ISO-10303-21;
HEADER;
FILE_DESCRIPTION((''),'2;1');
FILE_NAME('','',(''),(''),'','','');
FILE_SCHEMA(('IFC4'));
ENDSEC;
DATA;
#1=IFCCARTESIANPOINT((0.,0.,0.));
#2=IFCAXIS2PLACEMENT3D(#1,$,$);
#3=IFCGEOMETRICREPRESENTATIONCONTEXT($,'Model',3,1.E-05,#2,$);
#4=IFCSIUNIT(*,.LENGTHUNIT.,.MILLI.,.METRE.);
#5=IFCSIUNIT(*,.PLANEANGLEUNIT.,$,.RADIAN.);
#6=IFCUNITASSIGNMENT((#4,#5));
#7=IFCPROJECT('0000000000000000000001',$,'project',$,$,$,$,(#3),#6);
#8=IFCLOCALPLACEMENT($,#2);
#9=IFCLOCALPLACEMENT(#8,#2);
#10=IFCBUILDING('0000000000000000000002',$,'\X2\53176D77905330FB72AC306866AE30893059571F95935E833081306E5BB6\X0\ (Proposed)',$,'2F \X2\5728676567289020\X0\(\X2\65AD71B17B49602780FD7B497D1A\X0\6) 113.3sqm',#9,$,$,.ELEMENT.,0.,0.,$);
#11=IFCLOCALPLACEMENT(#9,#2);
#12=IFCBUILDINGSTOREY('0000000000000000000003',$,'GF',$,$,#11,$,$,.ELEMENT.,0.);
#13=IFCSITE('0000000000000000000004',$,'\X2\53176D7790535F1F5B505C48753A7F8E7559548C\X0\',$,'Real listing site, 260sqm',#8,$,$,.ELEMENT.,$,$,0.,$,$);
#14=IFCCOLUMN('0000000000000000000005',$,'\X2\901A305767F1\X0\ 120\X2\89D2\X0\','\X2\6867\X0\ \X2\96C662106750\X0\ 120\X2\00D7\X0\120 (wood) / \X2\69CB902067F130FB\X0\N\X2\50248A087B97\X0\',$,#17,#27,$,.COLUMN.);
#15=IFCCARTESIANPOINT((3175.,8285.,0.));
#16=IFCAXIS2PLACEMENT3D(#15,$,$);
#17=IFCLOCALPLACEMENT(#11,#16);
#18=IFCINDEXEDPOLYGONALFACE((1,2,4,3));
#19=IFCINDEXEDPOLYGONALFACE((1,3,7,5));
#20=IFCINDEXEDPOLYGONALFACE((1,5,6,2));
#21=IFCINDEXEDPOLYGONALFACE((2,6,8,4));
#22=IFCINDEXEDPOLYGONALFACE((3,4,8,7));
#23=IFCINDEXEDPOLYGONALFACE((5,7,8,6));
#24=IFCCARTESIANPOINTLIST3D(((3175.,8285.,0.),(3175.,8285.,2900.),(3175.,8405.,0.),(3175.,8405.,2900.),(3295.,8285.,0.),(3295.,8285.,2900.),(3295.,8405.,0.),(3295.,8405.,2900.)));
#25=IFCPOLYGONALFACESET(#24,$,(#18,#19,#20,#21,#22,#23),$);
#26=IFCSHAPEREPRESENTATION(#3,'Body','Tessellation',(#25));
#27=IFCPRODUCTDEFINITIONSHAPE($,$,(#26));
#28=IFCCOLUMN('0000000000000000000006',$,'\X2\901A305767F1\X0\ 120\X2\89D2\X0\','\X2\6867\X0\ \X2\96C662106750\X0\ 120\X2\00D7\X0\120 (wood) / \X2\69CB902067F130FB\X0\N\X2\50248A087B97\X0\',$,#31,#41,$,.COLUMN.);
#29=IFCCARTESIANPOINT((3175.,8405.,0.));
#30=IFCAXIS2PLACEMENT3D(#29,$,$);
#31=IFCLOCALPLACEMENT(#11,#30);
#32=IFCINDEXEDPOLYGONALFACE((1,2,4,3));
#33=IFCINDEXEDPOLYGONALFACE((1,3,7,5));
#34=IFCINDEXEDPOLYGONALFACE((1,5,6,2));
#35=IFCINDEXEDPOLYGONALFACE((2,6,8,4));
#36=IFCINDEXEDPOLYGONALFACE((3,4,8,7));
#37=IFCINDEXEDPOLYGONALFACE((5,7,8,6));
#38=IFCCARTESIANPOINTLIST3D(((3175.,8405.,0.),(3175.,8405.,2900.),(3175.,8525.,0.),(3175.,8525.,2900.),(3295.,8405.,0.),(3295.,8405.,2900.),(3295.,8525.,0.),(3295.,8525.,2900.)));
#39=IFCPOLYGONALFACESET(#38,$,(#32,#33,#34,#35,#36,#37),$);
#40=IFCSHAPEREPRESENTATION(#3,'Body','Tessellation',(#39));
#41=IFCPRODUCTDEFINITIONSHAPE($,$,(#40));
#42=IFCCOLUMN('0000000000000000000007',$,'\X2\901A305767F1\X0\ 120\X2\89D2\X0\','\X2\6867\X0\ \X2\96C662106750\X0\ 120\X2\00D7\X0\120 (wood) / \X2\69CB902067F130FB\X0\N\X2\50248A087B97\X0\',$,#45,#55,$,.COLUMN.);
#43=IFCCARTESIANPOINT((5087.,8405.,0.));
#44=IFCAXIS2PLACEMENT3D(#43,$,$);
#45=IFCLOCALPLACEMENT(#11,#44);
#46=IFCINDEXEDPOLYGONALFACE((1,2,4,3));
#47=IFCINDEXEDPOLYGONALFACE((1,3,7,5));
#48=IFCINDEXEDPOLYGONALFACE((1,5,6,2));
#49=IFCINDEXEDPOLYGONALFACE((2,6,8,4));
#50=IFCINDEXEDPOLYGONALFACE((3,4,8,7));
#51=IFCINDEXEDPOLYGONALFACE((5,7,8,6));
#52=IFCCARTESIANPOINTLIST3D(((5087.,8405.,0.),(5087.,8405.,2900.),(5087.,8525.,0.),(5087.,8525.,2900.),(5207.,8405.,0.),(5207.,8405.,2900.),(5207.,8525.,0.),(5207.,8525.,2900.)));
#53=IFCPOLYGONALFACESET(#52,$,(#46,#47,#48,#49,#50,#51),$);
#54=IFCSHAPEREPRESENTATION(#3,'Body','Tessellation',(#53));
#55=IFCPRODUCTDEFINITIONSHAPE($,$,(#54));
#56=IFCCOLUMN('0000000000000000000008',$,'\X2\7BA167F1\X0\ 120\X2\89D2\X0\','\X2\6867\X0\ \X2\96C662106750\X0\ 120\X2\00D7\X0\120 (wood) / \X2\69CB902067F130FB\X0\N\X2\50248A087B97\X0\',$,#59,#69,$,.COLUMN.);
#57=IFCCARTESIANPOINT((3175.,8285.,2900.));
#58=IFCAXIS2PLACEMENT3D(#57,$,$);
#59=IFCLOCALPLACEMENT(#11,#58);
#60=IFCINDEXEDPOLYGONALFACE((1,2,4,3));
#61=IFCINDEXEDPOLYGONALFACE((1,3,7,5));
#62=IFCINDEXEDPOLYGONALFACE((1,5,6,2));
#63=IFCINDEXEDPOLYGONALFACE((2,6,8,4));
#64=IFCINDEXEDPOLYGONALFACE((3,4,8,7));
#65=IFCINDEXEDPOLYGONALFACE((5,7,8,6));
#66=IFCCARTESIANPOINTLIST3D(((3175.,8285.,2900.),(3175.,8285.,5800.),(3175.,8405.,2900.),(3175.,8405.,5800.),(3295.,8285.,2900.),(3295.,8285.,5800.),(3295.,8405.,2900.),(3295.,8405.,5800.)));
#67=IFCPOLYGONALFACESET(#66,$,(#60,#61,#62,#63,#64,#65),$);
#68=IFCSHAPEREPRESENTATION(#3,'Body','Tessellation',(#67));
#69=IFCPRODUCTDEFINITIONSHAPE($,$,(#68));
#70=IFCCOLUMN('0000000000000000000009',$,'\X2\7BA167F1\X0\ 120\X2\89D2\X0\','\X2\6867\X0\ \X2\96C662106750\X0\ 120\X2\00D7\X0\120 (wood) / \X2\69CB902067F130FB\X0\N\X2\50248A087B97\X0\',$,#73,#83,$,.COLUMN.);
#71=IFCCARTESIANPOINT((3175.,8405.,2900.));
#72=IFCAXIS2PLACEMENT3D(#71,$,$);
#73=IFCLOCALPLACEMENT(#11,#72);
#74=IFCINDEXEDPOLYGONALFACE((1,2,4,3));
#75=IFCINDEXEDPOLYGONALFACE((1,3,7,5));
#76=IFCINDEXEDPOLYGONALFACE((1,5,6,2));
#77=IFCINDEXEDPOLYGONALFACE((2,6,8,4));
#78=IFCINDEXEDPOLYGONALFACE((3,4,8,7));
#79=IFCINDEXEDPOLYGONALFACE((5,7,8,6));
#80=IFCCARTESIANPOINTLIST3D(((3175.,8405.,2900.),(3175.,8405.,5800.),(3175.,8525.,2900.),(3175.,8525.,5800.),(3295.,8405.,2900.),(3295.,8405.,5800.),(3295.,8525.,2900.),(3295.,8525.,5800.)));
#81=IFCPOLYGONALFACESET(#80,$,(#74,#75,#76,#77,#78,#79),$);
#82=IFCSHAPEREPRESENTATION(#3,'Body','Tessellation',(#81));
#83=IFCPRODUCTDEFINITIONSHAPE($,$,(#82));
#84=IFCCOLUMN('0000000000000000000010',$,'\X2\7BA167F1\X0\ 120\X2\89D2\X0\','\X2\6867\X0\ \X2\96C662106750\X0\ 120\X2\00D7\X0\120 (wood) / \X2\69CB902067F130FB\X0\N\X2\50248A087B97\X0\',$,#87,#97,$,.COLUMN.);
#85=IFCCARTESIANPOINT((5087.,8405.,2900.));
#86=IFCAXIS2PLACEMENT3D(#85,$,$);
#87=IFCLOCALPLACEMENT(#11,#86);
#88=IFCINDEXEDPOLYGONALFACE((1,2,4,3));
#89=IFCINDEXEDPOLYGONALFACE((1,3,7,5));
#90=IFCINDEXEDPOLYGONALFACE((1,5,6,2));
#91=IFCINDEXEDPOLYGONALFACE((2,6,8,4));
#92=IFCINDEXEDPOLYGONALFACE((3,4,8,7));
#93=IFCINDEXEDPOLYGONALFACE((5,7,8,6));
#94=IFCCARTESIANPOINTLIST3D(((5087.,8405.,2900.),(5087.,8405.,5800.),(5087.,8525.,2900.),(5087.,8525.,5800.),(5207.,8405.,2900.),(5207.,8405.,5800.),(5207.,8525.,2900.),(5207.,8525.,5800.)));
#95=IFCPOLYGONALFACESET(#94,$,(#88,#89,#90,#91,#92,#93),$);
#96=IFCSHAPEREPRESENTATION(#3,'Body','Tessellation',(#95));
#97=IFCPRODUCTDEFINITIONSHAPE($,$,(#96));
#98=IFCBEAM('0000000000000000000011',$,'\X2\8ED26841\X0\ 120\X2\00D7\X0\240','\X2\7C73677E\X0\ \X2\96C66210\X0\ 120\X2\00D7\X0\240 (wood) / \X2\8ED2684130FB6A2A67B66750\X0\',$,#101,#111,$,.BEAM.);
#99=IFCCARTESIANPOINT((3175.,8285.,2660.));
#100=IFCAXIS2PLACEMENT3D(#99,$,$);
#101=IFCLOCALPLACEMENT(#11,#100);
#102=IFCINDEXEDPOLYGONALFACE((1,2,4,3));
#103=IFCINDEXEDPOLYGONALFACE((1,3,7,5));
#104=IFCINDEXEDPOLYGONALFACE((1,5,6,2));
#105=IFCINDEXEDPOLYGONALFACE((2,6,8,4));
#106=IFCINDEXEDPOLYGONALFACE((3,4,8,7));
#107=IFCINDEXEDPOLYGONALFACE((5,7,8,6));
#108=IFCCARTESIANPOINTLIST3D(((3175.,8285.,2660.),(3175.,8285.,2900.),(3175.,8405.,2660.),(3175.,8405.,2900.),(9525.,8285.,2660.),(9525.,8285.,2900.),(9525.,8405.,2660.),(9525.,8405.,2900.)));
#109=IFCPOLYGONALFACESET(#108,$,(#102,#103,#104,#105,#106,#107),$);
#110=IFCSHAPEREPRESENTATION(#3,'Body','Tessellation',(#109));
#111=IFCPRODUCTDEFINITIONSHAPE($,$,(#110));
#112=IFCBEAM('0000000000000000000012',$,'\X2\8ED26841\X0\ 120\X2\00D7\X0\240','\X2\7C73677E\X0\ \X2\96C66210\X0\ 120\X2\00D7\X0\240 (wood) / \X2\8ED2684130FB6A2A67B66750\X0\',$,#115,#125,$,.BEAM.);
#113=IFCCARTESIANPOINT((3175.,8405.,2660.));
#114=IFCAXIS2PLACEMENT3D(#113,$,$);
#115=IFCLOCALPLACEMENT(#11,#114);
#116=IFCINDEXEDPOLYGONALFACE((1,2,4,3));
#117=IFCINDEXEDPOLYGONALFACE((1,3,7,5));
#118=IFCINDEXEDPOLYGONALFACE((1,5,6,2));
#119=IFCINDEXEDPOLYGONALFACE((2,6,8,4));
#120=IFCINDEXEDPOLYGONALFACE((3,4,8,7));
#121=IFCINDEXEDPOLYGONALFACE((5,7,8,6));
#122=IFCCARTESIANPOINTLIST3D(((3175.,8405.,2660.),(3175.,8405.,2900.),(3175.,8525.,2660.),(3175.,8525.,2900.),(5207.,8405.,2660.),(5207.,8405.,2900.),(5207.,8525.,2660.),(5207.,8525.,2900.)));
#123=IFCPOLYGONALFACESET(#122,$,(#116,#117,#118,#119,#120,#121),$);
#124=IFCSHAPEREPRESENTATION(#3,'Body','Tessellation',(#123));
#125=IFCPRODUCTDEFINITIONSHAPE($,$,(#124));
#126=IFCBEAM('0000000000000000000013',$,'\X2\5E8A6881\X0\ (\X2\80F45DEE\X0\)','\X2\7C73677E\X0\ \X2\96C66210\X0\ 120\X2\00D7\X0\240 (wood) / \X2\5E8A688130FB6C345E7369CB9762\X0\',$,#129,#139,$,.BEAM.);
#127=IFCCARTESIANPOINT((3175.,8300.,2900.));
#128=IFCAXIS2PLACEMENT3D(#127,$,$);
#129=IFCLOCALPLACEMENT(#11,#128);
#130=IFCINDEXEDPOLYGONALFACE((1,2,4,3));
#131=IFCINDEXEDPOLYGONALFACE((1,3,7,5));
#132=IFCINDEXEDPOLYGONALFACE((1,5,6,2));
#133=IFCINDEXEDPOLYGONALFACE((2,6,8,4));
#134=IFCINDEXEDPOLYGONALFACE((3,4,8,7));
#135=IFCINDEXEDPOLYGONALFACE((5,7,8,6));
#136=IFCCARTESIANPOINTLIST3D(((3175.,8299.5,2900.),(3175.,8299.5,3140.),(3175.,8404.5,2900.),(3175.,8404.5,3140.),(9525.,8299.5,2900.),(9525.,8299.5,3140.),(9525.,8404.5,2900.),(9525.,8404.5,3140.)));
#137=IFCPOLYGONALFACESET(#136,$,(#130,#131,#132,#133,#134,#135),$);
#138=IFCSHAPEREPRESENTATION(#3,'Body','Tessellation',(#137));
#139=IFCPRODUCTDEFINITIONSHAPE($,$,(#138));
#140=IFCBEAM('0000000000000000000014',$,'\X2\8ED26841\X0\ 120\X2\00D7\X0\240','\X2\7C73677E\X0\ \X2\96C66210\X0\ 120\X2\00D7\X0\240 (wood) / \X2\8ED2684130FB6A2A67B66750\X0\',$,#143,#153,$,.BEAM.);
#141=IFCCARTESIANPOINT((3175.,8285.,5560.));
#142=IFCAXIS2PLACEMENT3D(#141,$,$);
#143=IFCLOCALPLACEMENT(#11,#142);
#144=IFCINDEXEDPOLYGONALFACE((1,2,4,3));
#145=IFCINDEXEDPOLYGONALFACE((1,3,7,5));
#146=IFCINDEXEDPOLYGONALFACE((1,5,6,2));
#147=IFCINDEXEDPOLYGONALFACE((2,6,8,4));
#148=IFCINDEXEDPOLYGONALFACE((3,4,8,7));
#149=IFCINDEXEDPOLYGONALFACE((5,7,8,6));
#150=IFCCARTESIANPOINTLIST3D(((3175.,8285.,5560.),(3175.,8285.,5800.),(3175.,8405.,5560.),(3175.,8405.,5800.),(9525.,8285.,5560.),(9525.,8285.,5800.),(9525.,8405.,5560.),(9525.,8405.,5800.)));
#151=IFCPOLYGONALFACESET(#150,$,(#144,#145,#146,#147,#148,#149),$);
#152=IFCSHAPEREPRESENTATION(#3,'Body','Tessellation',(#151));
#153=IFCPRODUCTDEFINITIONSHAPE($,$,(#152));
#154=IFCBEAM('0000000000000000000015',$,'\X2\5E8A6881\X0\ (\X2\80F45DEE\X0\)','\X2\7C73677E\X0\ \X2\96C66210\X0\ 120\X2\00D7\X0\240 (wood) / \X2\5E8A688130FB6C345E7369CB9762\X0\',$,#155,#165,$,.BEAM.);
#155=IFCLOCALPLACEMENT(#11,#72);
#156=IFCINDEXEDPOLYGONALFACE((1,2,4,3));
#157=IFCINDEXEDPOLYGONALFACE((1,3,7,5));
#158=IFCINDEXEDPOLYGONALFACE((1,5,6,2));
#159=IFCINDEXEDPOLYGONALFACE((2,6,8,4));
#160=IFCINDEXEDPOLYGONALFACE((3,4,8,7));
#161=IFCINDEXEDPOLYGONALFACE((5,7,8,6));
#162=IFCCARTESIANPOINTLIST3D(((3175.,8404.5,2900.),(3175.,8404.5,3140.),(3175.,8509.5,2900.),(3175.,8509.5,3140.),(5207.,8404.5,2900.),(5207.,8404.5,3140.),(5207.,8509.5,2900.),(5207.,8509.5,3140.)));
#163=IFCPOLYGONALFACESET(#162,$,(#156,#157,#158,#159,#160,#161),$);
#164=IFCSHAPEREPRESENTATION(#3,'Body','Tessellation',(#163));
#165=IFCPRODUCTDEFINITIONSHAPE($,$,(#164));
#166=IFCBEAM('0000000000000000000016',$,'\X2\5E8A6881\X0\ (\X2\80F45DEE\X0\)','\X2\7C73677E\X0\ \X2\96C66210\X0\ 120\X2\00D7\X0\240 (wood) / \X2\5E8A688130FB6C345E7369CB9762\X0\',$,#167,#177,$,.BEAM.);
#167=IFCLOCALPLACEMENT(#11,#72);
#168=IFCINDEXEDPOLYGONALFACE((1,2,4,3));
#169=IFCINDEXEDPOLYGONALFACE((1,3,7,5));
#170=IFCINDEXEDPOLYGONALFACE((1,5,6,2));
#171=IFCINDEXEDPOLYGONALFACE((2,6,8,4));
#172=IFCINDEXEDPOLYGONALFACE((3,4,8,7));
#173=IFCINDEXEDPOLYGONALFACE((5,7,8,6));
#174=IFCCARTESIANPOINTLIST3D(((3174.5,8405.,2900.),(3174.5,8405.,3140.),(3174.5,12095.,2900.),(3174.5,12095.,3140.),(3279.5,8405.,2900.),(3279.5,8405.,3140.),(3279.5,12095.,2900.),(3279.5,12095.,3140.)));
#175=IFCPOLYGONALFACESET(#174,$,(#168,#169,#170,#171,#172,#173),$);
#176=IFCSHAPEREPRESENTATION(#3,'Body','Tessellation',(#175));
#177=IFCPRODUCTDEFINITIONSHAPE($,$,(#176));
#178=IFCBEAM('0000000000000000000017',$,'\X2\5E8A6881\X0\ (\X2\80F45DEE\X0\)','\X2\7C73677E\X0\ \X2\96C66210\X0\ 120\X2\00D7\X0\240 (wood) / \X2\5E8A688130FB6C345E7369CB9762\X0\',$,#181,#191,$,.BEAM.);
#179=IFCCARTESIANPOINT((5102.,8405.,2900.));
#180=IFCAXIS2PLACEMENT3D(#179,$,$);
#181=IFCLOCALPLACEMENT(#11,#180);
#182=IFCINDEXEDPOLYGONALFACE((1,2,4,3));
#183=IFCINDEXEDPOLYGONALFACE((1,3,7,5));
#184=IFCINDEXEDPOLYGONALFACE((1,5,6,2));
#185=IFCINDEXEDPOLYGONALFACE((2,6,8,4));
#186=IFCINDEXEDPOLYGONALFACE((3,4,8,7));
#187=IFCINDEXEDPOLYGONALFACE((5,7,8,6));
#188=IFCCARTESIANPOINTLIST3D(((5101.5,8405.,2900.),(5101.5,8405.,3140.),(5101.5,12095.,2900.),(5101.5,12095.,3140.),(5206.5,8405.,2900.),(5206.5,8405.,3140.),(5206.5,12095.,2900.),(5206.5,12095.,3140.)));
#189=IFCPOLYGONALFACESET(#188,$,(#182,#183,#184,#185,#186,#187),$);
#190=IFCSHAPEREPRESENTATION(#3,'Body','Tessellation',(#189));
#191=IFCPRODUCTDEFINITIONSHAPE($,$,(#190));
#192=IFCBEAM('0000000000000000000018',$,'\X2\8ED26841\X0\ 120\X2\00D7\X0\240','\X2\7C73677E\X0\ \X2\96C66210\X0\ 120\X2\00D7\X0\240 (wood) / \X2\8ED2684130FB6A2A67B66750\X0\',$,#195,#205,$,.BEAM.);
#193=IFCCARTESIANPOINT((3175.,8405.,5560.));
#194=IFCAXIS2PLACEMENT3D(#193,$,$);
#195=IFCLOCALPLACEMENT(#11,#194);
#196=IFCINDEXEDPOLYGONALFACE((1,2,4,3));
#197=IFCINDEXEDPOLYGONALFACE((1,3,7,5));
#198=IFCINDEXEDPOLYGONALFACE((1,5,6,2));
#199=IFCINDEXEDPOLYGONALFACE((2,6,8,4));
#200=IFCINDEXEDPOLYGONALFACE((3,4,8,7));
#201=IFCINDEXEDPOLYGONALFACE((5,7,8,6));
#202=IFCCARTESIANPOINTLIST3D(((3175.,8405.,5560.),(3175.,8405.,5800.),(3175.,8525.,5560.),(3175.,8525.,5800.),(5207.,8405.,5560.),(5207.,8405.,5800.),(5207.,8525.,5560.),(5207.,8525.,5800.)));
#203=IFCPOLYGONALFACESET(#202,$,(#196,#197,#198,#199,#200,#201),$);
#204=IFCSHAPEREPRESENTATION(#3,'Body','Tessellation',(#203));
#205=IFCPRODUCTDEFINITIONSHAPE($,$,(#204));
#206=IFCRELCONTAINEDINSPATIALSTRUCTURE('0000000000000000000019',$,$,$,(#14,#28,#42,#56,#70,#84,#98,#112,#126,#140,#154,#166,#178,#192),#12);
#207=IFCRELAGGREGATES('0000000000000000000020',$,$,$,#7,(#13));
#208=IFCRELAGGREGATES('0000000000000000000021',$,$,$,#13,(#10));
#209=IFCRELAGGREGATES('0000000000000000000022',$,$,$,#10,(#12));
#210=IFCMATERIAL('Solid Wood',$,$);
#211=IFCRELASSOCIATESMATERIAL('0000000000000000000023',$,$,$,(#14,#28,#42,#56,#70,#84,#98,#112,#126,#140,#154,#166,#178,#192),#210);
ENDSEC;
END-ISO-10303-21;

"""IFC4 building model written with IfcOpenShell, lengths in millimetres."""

from ifc_helpers import new_model, si_unit, frame, frame_2d, origin, place, context, project, spatial, rectangle, extrude, material, element, save


model = new_model("IFC4")

# Units and contexts
model_context = context("Model", 3, precision=1e-05, world=origin())
ifc_project = project(units=[si_unit("LENGTHUNIT", "METRE", prefix="MILLI"), si_unit("PLANEANGLEUNIT", "RADIAN")], contexts=[model_context])

# Site, building, storey
site_placement = place(None, origin())
site = spatial("IfcSite", under=ifc_project, at=site_placement, Name="北海道弟子屈町美留和", ObjectType="Real listing site, 260sqm", CompositionType="ELEMENT", RefElevation=0.0)
building_placement = place(site_placement, origin())
building = spatial("IfcBuilding", under=site, at=building_placement, Name="北海道・犬と暮らす土間広めの家 (Proposed)", ObjectType="2F 在来木造(断熱等性能等級6) 113.3sqm", CompositionType="ELEMENT", ElevationOfRefHeight=0.0, ElevationOfTerrain=0.0)
storey_placement = place(building_placement, origin())
storey = spatial("IfcBuildingStorey", under=building, at=storey_placement, Name="GF", CompositionType="ELEMENT", Elevation=0.0)

# Columns
ifc_material_1 = material(Name="Solid Wood")
column_1_placement = place(storey_placement, frame((3175.0, 8285.0, 0.0)))
element("IfcColumn", 1, at=column_1_placement, inside=storey, material=ifc_material_1, Name="通し柱 120角", Description="桧 集成材 120×120 (wood) / 構造柱・N値計算", PredefinedType="COLUMN", context=model_context, shape_type="SweptSolid", body=[
    extrude(rectangle(XDim=120.0, YDim=120.0, at=frame_2d((60.0, 60.0))), frame((3175.0, 8285.0, 0.0)), (0.0, 0.0, 1.0), 2900.0),
])
column_2_placement = place(storey_placement, frame((3175.0, 8405.0, 0.0)))
element("IfcColumn", 2, at=column_2_placement, inside=storey, material=ifc_material_1, Name="通し柱 120角", Description="桧 集成材 120×120 (wood) / 構造柱・N値計算", PredefinedType="COLUMN", context=model_context, shape_type="SweptSolid", body=[
    extrude(rectangle(XDim=120.0, YDim=120.0, at=frame_2d((60.0, 60.0))), frame((3175.0, 8405.0, 0.0)), (0.0, 0.0, 1.0), 2900.0),
])
column_3_placement = place(storey_placement, frame((5087.0, 8405.0, 0.0)))
element("IfcColumn", 3, at=column_3_placement, inside=storey, material=ifc_material_1, Name="通し柱 120角", Description="桧 集成材 120×120 (wood) / 構造柱・N値計算", PredefinedType="COLUMN", context=model_context, shape_type="SweptSolid", body=[
    extrude(rectangle(XDim=120.0, YDim=120.0, at=frame_2d((60.0, 60.0))), frame((5087.0, 8405.0, 0.0)), (0.0, 0.0, 1.0), 2900.0),
])
column_4_placement = place(storey_placement, frame((3175.0, 8285.0, 2900.0)))
element("IfcColumn", 4, at=column_4_placement, inside=storey, material=ifc_material_1, Name="管柱 120角", Description="桧 集成材 120×120 (wood) / 構造柱・N値計算", PredefinedType="COLUMN", context=model_context, shape_type="SweptSolid", body=[
    extrude(rectangle(XDim=120.0, YDim=120.0, at=frame_2d((60.0, 60.0))), frame((3175.0, 8285.0, 2900.0)), (0.0, 0.0, 1.0), 2900.0),
])
column_5_placement = place(storey_placement, frame((3175.0, 8405.0, 2900.0)))
element("IfcColumn", 5, at=column_5_placement, inside=storey, material=ifc_material_1, Name="管柱 120角", Description="桧 集成材 120×120 (wood) / 構造柱・N値計算", PredefinedType="COLUMN", context=model_context, shape_type="SweptSolid", body=[
    extrude(rectangle(XDim=120.0, YDim=120.0, at=frame_2d((60.0, 60.0))), frame((3175.0, 8405.0, 2900.0)), (0.0, 0.0, 1.0), 2900.0),
])
column_6_placement = place(storey_placement, frame((5087.0, 8405.0, 2900.0)))
element("IfcColumn", 6, at=column_6_placement, inside=storey, material=ifc_material_1, Name="管柱 120角", Description="桧 集成材 120×120 (wood) / 構造柱・N値計算", PredefinedType="COLUMN", context=model_context, shape_type="SweptSolid", body=[
    extrude(rectangle(XDim=120.0, YDim=120.0, at=frame_2d((60.0, 60.0))), frame((5087.0, 8405.0, 2900.0)), (0.0, 0.0, 1.0), 2900.0),
])

# Beams
beam_1_placement = place(storey_placement, frame((3175.0, 8285.0, 2660.0)))
element("IfcBeam", 7, at=beam_1_placement, inside=storey, material=ifc_material_1, Name="軒桁 120×240", Description="米松 集成 120×240 (wood) / 軒桁・横架材", PredefinedType="BEAM", context=model_context, shape_type="SweptSolid", body=[
    extrude(rectangle(XDim=6350.0, YDim=120.0, at=frame_2d((3175.0, 60.0))), frame((3175.0, 8285.0, 2660.0)), (0.0, 0.0, 1.0), 240.0),
])
beam_2_placement = place(storey_placement, frame((3175.0, 8405.0, 2660.0)))
element("IfcBeam", 8, at=beam_2_placement, inside=storey, material=ifc_material_1, Name="軒桁 120×240", Description="米松 集成 120×240 (wood) / 軒桁・横架材", PredefinedType="BEAM", context=model_context, shape_type="SweptSolid", body=[
    extrude(rectangle(XDim=2032.0, YDim=120.0, at=frame_2d((1016.0, 60.0))), frame((3175.0, 8405.0, 2660.0)), (0.0, 0.0, 1.0), 240.0),
])
beam_3_placement = place(storey_placement, frame((3175.0, 8300.0, 2900.0)))
element("IfcBeam", 9, at=beam_3_placement, inside=storey, material=ifc_material_1, Name="床梁 (胴差)", Description="米松 集成 120×240 (wood) / 床梁・水平構面", PredefinedType="BEAM", context=model_context, shape_type="SweptSolid", body=[
    extrude(rectangle(XDim=6350.0, YDim=105.0, at=frame_2d((3175.0, 52.0))), frame((3175.0, 8300.0, 2900.0)), (0.0, 0.0, 1.0), 240.0),
])
beam_4_placement = place(storey_placement, frame((3175.0, 8285.0, 5560.0)))
element("IfcBeam", 10, at=beam_4_placement, inside=storey, material=ifc_material_1, Name="軒桁 120×240", Description="米松 集成 120×240 (wood) / 軒桁・横架材", PredefinedType="BEAM", context=model_context, shape_type="SweptSolid", body=[
    extrude(rectangle(XDim=6350.0, YDim=120.0, at=frame_2d((3175.0, 60.0))), frame((3175.0, 8285.0, 5560.0)), (0.0, 0.0, 1.0), 240.0),
])
beam_5_placement = place(storey_placement, frame((3175.0, 8405.0, 2900.0)))
element("IfcBeam", 11, at=beam_5_placement, inside=storey, material=ifc_material_1, Name="床梁 (胴差)", Description="米松 集成 120×240 (wood) / 床梁・水平構面", PredefinedType="BEAM", context=model_context, shape_type="SweptSolid", body=[
    extrude(rectangle(XDim=2032.0, YDim=105.0, at=frame_2d((1016.0, 52.0))), frame((3175.0, 8405.0, 2900.0)), (0.0, 0.0, 1.0), 240.0),
])
beam_6_placement = place(storey_placement, frame((3175.0, 8405.0, 2900.0)))
element("IfcBeam", 12, at=beam_6_placement, inside=storey, material=ifc_material_1, Name="床梁 (胴差)", Description="米松 集成 120×240 (wood) / 床梁・水平構面", PredefinedType="BEAM", context=model_context, shape_type="SweptSolid", body=[
    extrude(rectangle(XDim=105.0, YDim=3690.0, at=frame_2d((52.0, 1845.0))), frame((3175.0, 8405.0, 2900.0)), (0.0, 0.0, 1.0), 240.0),
])
beam_7_placement = place(storey_placement, frame((5102.0, 8405.0, 2900.0)))
element("IfcBeam", 13, at=beam_7_placement, inside=storey, material=ifc_material_1, Name="床梁 (胴差)", Description="米松 集成 120×240 (wood) / 床梁・水平構面", PredefinedType="BEAM", context=model_context, shape_type="SweptSolid", body=[
    extrude(rectangle(XDim=105.0, YDim=3690.0, at=frame_2d((52.0, 1845.0))), frame((5102.0, 8405.0, 2900.0)), (0.0, 0.0, 1.0), 240.0),
])
beam_8_placement = place(storey_placement, frame((3175.0, 8405.0, 5560.0)))
element("IfcBeam", 14, at=beam_8_placement, inside=storey, material=ifc_material_1, Name="軒桁 120×240", Description="米松 集成 120×240 (wood) / 軒桁・横架材", PredefinedType="BEAM", context=model_context, shape_type="SweptSolid", body=[
    extrude(rectangle(XDim=2032.0, YDim=120.0, at=frame_2d((1016.0, 60.0))), frame((3175.0, 8405.0, 5560.0)), (0.0, 0.0, 1.0), 240.0),
])

save(model, "model.ifc")
